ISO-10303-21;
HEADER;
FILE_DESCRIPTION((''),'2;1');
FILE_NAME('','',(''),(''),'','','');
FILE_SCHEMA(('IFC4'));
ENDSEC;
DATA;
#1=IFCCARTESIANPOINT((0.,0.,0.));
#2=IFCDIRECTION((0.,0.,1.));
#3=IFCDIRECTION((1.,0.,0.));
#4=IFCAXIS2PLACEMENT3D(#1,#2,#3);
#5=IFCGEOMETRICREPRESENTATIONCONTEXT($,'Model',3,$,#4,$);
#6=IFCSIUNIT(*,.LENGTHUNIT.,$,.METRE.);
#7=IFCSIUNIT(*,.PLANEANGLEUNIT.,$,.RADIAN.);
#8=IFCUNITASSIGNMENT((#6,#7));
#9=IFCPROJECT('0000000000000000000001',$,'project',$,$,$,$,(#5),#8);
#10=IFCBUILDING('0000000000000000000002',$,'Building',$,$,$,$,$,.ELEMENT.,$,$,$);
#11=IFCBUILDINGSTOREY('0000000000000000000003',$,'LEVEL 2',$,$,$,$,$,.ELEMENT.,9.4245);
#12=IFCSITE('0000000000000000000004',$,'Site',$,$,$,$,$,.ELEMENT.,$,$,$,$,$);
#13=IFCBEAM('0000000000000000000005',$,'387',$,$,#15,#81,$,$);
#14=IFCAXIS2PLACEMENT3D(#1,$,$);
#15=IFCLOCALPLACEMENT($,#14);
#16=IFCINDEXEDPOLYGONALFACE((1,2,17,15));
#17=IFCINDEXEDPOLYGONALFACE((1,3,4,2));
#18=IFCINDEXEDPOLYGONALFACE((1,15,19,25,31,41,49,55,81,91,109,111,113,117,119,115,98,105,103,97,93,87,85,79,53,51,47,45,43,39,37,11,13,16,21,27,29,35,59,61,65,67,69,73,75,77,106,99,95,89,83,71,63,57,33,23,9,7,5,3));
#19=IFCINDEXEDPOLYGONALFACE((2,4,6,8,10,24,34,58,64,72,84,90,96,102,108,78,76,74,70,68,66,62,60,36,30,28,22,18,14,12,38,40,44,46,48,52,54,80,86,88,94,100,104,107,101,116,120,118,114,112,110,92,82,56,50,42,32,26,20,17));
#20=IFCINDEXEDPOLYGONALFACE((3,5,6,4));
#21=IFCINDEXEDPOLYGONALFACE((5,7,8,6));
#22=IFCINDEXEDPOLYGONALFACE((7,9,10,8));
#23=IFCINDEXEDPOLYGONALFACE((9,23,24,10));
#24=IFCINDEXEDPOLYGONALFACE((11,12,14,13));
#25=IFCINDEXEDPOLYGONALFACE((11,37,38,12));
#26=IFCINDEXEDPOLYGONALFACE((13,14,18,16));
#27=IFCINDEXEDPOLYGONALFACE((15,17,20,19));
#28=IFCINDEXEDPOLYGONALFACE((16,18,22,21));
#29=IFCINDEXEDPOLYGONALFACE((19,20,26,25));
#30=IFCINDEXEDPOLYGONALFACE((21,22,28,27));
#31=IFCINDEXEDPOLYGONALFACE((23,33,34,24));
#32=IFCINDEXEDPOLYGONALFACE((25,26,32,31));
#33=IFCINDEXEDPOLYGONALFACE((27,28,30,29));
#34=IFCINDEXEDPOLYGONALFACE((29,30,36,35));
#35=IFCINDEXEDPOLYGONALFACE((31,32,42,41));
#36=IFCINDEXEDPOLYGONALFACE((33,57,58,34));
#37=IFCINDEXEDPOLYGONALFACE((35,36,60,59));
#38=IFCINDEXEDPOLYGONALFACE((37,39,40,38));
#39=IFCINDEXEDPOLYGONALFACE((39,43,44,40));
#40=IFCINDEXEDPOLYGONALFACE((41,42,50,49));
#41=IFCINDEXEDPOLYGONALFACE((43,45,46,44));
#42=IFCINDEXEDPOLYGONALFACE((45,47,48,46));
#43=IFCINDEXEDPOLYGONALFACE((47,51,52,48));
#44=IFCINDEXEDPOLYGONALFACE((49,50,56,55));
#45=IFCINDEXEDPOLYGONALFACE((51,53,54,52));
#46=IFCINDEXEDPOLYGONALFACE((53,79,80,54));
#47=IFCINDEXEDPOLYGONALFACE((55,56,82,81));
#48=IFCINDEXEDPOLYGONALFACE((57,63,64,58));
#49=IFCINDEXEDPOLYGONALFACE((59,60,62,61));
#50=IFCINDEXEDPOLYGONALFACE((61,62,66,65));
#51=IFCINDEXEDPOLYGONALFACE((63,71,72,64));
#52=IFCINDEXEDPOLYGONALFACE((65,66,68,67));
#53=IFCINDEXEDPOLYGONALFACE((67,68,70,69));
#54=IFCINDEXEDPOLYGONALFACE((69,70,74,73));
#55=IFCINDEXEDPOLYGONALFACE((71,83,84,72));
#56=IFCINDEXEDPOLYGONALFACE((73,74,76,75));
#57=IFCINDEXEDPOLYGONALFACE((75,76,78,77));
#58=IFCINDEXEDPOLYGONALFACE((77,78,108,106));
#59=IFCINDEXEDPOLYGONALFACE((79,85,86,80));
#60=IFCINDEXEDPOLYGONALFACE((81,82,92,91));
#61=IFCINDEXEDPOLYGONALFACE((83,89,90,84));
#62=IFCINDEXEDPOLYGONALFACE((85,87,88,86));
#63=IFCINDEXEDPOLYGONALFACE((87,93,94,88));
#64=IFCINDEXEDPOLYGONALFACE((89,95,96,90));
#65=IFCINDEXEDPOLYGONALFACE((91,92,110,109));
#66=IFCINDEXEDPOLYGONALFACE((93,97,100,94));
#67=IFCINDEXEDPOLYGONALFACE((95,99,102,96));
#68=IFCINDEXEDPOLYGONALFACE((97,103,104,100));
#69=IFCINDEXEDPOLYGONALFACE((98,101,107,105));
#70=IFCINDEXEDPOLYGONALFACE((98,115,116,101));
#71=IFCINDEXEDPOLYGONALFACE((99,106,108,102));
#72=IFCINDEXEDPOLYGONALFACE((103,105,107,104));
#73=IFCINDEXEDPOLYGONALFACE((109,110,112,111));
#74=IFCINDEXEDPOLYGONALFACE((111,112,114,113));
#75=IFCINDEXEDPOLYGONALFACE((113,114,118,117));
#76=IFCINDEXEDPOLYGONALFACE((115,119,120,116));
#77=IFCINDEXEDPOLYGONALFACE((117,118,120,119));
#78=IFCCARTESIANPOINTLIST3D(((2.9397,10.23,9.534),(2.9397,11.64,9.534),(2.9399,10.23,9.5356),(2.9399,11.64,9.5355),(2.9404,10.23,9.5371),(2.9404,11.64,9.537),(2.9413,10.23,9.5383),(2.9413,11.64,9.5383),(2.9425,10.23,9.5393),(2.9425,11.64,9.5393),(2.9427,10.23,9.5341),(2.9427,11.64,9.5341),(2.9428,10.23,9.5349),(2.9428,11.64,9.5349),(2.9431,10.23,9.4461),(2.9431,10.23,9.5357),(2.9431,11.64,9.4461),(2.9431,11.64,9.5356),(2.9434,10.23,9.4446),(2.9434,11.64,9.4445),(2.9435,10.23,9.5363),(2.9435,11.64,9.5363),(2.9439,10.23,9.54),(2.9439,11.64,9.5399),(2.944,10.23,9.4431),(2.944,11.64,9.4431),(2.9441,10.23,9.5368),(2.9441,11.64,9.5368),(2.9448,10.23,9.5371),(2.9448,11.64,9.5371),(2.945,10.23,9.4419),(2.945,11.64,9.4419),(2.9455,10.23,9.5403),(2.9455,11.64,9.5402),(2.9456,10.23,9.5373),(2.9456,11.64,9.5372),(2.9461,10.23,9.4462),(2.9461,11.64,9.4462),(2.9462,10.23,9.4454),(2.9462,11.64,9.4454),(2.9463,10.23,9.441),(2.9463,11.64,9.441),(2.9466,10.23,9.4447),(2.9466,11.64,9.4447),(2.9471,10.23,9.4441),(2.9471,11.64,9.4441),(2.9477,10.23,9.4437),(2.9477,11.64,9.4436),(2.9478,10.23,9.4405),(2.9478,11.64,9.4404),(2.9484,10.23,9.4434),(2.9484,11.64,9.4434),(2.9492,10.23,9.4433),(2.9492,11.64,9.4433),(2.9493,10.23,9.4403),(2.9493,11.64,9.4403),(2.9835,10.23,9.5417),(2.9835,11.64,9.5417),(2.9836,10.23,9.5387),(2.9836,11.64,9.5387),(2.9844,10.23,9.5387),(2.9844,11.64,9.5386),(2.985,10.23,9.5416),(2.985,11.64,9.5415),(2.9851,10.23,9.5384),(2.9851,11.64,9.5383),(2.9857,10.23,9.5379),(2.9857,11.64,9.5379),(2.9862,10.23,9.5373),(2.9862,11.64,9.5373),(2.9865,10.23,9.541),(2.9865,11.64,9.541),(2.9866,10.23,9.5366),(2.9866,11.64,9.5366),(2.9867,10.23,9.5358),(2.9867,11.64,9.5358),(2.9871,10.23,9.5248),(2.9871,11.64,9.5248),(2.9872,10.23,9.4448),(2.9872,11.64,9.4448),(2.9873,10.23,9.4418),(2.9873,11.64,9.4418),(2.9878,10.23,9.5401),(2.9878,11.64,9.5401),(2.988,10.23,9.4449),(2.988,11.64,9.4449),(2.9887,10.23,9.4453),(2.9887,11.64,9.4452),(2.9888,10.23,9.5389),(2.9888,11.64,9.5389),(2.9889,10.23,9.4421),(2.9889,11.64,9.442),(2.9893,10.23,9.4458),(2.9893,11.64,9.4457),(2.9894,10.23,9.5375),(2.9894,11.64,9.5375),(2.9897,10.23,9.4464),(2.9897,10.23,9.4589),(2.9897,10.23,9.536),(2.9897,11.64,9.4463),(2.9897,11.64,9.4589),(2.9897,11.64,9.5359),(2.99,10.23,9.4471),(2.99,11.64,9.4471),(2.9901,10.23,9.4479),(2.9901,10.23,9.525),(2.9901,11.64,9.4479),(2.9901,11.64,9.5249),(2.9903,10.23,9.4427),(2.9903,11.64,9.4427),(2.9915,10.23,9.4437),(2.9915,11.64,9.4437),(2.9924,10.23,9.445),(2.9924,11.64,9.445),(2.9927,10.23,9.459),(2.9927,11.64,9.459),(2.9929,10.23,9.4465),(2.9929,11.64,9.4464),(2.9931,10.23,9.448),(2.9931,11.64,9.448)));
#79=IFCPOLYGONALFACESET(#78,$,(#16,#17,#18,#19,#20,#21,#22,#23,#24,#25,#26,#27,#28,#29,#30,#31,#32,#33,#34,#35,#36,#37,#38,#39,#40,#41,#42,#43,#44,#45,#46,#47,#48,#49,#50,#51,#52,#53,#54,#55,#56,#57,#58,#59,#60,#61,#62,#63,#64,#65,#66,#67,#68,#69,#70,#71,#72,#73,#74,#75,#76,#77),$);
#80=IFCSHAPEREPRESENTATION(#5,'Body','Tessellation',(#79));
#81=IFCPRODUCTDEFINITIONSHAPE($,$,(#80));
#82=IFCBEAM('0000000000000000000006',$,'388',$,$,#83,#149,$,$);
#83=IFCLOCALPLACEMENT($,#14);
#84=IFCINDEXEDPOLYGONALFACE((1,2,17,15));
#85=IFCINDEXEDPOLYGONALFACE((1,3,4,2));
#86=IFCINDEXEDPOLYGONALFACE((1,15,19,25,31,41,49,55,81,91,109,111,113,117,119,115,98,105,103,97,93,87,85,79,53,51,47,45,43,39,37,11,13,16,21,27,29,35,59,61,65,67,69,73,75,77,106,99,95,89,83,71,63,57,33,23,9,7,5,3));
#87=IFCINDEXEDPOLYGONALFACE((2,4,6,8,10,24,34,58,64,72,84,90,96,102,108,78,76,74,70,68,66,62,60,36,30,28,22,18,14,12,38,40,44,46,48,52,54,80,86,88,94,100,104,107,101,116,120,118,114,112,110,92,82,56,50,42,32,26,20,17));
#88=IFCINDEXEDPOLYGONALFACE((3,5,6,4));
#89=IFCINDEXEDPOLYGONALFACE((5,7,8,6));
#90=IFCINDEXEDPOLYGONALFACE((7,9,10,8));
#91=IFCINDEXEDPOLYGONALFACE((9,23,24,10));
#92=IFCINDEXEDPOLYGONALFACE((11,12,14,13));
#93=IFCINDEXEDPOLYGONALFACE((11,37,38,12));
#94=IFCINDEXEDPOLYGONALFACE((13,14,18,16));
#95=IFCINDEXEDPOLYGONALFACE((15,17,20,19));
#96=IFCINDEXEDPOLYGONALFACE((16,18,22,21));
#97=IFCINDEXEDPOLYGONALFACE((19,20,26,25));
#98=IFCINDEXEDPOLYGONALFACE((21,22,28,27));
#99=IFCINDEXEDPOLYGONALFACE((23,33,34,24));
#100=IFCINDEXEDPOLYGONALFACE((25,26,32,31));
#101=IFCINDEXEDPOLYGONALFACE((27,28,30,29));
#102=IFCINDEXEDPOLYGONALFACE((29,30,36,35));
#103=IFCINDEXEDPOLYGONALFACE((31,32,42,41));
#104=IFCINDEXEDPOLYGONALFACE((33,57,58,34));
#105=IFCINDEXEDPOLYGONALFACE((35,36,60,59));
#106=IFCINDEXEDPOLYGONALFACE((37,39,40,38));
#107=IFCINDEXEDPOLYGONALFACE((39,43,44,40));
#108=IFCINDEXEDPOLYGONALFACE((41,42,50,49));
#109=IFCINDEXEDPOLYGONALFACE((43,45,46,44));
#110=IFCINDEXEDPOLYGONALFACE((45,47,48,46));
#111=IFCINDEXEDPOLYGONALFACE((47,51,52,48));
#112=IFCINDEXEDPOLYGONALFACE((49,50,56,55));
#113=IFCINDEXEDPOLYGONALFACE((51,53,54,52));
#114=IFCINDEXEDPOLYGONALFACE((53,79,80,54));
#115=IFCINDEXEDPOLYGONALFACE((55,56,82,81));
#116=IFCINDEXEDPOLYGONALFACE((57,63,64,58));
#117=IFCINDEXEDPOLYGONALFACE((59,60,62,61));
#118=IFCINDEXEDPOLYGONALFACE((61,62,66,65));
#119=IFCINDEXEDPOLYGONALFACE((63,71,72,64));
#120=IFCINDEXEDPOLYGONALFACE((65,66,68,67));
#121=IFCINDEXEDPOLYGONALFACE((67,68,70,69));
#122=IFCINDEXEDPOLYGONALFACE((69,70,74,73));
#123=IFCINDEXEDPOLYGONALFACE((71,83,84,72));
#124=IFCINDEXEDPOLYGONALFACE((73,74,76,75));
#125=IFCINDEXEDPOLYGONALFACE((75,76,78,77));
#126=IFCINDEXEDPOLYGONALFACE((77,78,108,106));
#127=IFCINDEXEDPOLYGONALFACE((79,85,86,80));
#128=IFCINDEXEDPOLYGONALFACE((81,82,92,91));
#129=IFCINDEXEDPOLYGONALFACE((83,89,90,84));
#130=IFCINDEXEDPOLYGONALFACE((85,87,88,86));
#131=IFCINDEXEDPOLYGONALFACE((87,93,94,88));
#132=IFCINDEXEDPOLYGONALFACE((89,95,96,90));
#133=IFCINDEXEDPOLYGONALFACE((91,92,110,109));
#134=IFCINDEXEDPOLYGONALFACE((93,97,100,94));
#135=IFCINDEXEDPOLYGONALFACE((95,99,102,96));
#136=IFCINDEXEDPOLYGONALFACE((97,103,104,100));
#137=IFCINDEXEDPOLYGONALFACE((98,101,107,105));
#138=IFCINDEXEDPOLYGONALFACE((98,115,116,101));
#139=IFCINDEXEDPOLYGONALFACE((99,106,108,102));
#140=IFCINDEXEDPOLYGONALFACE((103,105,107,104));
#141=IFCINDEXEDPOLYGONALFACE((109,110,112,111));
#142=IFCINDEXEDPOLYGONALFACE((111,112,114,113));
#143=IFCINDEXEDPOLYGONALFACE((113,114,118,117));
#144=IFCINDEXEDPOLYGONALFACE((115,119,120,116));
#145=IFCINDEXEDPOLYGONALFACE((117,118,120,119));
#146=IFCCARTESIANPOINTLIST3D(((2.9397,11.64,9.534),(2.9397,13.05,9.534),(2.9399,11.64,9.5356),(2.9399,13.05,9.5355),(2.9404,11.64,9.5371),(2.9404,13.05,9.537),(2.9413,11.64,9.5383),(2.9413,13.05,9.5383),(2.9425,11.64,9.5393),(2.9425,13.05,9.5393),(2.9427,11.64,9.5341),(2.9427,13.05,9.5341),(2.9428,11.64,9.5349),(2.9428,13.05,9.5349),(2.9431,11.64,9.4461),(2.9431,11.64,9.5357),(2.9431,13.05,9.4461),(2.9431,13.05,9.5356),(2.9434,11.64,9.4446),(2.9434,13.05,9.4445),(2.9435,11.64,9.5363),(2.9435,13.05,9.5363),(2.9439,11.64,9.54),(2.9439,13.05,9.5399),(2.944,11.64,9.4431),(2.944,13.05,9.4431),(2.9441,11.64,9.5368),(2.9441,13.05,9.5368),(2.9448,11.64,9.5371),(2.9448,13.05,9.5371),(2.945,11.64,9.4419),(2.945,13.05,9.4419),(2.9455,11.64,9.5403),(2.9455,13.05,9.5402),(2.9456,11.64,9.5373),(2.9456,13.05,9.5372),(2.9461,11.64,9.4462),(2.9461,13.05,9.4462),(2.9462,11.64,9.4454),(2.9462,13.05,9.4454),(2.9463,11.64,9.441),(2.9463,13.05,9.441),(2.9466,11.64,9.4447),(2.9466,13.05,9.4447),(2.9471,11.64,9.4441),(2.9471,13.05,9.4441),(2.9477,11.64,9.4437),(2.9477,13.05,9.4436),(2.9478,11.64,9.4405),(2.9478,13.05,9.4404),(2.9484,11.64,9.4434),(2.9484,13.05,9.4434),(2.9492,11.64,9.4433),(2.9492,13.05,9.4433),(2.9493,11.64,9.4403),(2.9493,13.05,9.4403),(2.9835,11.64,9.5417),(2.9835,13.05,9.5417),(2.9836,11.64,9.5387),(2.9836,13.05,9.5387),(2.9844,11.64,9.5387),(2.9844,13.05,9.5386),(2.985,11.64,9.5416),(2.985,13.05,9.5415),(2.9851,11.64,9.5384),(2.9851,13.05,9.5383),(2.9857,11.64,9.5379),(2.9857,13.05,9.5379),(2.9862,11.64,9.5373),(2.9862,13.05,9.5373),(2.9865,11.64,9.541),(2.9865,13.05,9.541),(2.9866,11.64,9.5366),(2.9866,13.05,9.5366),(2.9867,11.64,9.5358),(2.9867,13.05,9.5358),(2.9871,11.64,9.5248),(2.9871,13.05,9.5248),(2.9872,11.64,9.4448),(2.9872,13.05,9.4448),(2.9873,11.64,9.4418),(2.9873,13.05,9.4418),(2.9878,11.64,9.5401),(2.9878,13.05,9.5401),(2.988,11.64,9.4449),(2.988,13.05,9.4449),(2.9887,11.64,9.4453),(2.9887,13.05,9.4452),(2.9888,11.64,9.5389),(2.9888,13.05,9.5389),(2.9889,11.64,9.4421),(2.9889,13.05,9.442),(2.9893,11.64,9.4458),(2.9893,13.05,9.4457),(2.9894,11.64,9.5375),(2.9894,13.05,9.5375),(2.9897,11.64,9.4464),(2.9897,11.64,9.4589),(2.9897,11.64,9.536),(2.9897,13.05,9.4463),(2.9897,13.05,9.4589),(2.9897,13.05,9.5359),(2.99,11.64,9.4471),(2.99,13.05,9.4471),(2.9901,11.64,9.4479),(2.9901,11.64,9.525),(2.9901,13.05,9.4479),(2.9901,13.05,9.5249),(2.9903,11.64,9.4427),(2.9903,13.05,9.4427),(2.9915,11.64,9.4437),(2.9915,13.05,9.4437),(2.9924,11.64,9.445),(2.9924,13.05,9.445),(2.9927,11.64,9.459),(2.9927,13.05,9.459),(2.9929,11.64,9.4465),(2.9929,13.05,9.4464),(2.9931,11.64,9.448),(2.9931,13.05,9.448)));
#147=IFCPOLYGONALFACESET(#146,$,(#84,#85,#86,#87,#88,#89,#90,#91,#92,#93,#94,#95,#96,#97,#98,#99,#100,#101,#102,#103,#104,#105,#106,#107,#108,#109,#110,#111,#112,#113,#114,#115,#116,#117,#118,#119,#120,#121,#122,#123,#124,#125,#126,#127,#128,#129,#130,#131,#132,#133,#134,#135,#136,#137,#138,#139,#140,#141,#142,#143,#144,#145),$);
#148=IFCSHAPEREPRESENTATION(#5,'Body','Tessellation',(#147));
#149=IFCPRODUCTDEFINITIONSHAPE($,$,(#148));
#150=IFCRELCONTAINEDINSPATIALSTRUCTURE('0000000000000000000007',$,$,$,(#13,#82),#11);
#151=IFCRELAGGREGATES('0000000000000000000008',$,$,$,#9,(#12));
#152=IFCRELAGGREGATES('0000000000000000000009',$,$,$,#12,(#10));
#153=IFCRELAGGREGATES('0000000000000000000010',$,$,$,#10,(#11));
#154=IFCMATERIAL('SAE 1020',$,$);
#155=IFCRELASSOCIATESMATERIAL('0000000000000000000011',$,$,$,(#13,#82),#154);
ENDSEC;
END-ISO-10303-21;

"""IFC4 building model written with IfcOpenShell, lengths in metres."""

from ifc_helpers import new_model, si_unit, frame, origin_with_axes, origin_2d_with_axis, place, context, project, spatial, c_section, extrude, material, material_profile, profile_set, profile_usage, element, save


model = new_model("IFC4")

# Units and contexts
model_context = context("Model", 3, world=origin_with_axes())
ifc_project = project(units=[si_unit("LENGTHUNIT", "METRE"), si_unit("PLANEANGLEUNIT", "RADIAN")], contexts=[model_context])

# Site, building, storey
site = spatial("IfcSite", under=ifc_project, Name="Site", CompositionType="ELEMENT")
building = spatial("IfcBuilding", under=site, Name="Building", CompositionType="ELEMENT")
storey = spatial("IfcBuildingStorey", under=building, Name="LEVEL 2", CompositionType="ELEMENT", Elevation=9.4245)

# Beams
ifc_material = material(Name="SAE 1020")
ifc_material_profile_1 = material_profile(ifc_material, c_section(Depth=0.1, Width=0.05, WallThickness=0.003, Girth=0.017, InternalFilletRadius=0.003, at=origin_2d_with_axis()))
ifc_profile_set_1 = profile_set([ifc_material_profile_1])
ifc_profile_usage_1 = profile_usage(ifc_profile_set_1, cardinal=10)
beam_1_placement = place(None, frame((2.9664, 10.23, 9.491), z_axis=(0.0, 1.0, -0.00003), x_axis=(0.999256, 0.000001, 0.038562)))
element("IfcBeam", 1, at=beam_1_placement, inside=storey, material=ifc_profile_usage_1, Name="387", context=model_context, shape_type="SweptSolid", body=[
    extrude(c_section(Depth=0.1, Width=0.05, WallThickness=0.003, Girth=0.017, InternalFilletRadius=0.003, at=origin_2d_with_axis()), origin_with_axes(), (0.0, 0.0, 1.0), 1.41),
])
ifc_material_profile_2 = material_profile(ifc_material, c_section(Depth=0.1, Width=0.05, WallThickness=0.003, Girth=0.017, InternalFilletRadius=0.003, at=origin_2d_with_axis()))
ifc_profile_set_2 = profile_set([ifc_material_profile_2])
ifc_profile_usage_2 = profile_usage(ifc_profile_set_2, cardinal=10)
beam_2_placement = place(None, frame((2.9664, 11.64, 9.491), z_axis=(0.0, 1.0, -0.00003), x_axis=(0.999256, 0.000001, 0.038562)))
element("IfcBeam", 2, at=beam_2_placement, inside=storey, material=ifc_profile_usage_2, Name="388", context=model_context, shape_type="SweptSolid", body=[
    extrude(c_section(Depth=0.1, Width=0.05, WallThickness=0.003, Girth=0.017, InternalFilletRadius=0.003, at=origin_2d_with_axis()), origin_with_axes(), (0.0, 0.0, 1.0), 1.41),
])

save(model, "model.ifc")
